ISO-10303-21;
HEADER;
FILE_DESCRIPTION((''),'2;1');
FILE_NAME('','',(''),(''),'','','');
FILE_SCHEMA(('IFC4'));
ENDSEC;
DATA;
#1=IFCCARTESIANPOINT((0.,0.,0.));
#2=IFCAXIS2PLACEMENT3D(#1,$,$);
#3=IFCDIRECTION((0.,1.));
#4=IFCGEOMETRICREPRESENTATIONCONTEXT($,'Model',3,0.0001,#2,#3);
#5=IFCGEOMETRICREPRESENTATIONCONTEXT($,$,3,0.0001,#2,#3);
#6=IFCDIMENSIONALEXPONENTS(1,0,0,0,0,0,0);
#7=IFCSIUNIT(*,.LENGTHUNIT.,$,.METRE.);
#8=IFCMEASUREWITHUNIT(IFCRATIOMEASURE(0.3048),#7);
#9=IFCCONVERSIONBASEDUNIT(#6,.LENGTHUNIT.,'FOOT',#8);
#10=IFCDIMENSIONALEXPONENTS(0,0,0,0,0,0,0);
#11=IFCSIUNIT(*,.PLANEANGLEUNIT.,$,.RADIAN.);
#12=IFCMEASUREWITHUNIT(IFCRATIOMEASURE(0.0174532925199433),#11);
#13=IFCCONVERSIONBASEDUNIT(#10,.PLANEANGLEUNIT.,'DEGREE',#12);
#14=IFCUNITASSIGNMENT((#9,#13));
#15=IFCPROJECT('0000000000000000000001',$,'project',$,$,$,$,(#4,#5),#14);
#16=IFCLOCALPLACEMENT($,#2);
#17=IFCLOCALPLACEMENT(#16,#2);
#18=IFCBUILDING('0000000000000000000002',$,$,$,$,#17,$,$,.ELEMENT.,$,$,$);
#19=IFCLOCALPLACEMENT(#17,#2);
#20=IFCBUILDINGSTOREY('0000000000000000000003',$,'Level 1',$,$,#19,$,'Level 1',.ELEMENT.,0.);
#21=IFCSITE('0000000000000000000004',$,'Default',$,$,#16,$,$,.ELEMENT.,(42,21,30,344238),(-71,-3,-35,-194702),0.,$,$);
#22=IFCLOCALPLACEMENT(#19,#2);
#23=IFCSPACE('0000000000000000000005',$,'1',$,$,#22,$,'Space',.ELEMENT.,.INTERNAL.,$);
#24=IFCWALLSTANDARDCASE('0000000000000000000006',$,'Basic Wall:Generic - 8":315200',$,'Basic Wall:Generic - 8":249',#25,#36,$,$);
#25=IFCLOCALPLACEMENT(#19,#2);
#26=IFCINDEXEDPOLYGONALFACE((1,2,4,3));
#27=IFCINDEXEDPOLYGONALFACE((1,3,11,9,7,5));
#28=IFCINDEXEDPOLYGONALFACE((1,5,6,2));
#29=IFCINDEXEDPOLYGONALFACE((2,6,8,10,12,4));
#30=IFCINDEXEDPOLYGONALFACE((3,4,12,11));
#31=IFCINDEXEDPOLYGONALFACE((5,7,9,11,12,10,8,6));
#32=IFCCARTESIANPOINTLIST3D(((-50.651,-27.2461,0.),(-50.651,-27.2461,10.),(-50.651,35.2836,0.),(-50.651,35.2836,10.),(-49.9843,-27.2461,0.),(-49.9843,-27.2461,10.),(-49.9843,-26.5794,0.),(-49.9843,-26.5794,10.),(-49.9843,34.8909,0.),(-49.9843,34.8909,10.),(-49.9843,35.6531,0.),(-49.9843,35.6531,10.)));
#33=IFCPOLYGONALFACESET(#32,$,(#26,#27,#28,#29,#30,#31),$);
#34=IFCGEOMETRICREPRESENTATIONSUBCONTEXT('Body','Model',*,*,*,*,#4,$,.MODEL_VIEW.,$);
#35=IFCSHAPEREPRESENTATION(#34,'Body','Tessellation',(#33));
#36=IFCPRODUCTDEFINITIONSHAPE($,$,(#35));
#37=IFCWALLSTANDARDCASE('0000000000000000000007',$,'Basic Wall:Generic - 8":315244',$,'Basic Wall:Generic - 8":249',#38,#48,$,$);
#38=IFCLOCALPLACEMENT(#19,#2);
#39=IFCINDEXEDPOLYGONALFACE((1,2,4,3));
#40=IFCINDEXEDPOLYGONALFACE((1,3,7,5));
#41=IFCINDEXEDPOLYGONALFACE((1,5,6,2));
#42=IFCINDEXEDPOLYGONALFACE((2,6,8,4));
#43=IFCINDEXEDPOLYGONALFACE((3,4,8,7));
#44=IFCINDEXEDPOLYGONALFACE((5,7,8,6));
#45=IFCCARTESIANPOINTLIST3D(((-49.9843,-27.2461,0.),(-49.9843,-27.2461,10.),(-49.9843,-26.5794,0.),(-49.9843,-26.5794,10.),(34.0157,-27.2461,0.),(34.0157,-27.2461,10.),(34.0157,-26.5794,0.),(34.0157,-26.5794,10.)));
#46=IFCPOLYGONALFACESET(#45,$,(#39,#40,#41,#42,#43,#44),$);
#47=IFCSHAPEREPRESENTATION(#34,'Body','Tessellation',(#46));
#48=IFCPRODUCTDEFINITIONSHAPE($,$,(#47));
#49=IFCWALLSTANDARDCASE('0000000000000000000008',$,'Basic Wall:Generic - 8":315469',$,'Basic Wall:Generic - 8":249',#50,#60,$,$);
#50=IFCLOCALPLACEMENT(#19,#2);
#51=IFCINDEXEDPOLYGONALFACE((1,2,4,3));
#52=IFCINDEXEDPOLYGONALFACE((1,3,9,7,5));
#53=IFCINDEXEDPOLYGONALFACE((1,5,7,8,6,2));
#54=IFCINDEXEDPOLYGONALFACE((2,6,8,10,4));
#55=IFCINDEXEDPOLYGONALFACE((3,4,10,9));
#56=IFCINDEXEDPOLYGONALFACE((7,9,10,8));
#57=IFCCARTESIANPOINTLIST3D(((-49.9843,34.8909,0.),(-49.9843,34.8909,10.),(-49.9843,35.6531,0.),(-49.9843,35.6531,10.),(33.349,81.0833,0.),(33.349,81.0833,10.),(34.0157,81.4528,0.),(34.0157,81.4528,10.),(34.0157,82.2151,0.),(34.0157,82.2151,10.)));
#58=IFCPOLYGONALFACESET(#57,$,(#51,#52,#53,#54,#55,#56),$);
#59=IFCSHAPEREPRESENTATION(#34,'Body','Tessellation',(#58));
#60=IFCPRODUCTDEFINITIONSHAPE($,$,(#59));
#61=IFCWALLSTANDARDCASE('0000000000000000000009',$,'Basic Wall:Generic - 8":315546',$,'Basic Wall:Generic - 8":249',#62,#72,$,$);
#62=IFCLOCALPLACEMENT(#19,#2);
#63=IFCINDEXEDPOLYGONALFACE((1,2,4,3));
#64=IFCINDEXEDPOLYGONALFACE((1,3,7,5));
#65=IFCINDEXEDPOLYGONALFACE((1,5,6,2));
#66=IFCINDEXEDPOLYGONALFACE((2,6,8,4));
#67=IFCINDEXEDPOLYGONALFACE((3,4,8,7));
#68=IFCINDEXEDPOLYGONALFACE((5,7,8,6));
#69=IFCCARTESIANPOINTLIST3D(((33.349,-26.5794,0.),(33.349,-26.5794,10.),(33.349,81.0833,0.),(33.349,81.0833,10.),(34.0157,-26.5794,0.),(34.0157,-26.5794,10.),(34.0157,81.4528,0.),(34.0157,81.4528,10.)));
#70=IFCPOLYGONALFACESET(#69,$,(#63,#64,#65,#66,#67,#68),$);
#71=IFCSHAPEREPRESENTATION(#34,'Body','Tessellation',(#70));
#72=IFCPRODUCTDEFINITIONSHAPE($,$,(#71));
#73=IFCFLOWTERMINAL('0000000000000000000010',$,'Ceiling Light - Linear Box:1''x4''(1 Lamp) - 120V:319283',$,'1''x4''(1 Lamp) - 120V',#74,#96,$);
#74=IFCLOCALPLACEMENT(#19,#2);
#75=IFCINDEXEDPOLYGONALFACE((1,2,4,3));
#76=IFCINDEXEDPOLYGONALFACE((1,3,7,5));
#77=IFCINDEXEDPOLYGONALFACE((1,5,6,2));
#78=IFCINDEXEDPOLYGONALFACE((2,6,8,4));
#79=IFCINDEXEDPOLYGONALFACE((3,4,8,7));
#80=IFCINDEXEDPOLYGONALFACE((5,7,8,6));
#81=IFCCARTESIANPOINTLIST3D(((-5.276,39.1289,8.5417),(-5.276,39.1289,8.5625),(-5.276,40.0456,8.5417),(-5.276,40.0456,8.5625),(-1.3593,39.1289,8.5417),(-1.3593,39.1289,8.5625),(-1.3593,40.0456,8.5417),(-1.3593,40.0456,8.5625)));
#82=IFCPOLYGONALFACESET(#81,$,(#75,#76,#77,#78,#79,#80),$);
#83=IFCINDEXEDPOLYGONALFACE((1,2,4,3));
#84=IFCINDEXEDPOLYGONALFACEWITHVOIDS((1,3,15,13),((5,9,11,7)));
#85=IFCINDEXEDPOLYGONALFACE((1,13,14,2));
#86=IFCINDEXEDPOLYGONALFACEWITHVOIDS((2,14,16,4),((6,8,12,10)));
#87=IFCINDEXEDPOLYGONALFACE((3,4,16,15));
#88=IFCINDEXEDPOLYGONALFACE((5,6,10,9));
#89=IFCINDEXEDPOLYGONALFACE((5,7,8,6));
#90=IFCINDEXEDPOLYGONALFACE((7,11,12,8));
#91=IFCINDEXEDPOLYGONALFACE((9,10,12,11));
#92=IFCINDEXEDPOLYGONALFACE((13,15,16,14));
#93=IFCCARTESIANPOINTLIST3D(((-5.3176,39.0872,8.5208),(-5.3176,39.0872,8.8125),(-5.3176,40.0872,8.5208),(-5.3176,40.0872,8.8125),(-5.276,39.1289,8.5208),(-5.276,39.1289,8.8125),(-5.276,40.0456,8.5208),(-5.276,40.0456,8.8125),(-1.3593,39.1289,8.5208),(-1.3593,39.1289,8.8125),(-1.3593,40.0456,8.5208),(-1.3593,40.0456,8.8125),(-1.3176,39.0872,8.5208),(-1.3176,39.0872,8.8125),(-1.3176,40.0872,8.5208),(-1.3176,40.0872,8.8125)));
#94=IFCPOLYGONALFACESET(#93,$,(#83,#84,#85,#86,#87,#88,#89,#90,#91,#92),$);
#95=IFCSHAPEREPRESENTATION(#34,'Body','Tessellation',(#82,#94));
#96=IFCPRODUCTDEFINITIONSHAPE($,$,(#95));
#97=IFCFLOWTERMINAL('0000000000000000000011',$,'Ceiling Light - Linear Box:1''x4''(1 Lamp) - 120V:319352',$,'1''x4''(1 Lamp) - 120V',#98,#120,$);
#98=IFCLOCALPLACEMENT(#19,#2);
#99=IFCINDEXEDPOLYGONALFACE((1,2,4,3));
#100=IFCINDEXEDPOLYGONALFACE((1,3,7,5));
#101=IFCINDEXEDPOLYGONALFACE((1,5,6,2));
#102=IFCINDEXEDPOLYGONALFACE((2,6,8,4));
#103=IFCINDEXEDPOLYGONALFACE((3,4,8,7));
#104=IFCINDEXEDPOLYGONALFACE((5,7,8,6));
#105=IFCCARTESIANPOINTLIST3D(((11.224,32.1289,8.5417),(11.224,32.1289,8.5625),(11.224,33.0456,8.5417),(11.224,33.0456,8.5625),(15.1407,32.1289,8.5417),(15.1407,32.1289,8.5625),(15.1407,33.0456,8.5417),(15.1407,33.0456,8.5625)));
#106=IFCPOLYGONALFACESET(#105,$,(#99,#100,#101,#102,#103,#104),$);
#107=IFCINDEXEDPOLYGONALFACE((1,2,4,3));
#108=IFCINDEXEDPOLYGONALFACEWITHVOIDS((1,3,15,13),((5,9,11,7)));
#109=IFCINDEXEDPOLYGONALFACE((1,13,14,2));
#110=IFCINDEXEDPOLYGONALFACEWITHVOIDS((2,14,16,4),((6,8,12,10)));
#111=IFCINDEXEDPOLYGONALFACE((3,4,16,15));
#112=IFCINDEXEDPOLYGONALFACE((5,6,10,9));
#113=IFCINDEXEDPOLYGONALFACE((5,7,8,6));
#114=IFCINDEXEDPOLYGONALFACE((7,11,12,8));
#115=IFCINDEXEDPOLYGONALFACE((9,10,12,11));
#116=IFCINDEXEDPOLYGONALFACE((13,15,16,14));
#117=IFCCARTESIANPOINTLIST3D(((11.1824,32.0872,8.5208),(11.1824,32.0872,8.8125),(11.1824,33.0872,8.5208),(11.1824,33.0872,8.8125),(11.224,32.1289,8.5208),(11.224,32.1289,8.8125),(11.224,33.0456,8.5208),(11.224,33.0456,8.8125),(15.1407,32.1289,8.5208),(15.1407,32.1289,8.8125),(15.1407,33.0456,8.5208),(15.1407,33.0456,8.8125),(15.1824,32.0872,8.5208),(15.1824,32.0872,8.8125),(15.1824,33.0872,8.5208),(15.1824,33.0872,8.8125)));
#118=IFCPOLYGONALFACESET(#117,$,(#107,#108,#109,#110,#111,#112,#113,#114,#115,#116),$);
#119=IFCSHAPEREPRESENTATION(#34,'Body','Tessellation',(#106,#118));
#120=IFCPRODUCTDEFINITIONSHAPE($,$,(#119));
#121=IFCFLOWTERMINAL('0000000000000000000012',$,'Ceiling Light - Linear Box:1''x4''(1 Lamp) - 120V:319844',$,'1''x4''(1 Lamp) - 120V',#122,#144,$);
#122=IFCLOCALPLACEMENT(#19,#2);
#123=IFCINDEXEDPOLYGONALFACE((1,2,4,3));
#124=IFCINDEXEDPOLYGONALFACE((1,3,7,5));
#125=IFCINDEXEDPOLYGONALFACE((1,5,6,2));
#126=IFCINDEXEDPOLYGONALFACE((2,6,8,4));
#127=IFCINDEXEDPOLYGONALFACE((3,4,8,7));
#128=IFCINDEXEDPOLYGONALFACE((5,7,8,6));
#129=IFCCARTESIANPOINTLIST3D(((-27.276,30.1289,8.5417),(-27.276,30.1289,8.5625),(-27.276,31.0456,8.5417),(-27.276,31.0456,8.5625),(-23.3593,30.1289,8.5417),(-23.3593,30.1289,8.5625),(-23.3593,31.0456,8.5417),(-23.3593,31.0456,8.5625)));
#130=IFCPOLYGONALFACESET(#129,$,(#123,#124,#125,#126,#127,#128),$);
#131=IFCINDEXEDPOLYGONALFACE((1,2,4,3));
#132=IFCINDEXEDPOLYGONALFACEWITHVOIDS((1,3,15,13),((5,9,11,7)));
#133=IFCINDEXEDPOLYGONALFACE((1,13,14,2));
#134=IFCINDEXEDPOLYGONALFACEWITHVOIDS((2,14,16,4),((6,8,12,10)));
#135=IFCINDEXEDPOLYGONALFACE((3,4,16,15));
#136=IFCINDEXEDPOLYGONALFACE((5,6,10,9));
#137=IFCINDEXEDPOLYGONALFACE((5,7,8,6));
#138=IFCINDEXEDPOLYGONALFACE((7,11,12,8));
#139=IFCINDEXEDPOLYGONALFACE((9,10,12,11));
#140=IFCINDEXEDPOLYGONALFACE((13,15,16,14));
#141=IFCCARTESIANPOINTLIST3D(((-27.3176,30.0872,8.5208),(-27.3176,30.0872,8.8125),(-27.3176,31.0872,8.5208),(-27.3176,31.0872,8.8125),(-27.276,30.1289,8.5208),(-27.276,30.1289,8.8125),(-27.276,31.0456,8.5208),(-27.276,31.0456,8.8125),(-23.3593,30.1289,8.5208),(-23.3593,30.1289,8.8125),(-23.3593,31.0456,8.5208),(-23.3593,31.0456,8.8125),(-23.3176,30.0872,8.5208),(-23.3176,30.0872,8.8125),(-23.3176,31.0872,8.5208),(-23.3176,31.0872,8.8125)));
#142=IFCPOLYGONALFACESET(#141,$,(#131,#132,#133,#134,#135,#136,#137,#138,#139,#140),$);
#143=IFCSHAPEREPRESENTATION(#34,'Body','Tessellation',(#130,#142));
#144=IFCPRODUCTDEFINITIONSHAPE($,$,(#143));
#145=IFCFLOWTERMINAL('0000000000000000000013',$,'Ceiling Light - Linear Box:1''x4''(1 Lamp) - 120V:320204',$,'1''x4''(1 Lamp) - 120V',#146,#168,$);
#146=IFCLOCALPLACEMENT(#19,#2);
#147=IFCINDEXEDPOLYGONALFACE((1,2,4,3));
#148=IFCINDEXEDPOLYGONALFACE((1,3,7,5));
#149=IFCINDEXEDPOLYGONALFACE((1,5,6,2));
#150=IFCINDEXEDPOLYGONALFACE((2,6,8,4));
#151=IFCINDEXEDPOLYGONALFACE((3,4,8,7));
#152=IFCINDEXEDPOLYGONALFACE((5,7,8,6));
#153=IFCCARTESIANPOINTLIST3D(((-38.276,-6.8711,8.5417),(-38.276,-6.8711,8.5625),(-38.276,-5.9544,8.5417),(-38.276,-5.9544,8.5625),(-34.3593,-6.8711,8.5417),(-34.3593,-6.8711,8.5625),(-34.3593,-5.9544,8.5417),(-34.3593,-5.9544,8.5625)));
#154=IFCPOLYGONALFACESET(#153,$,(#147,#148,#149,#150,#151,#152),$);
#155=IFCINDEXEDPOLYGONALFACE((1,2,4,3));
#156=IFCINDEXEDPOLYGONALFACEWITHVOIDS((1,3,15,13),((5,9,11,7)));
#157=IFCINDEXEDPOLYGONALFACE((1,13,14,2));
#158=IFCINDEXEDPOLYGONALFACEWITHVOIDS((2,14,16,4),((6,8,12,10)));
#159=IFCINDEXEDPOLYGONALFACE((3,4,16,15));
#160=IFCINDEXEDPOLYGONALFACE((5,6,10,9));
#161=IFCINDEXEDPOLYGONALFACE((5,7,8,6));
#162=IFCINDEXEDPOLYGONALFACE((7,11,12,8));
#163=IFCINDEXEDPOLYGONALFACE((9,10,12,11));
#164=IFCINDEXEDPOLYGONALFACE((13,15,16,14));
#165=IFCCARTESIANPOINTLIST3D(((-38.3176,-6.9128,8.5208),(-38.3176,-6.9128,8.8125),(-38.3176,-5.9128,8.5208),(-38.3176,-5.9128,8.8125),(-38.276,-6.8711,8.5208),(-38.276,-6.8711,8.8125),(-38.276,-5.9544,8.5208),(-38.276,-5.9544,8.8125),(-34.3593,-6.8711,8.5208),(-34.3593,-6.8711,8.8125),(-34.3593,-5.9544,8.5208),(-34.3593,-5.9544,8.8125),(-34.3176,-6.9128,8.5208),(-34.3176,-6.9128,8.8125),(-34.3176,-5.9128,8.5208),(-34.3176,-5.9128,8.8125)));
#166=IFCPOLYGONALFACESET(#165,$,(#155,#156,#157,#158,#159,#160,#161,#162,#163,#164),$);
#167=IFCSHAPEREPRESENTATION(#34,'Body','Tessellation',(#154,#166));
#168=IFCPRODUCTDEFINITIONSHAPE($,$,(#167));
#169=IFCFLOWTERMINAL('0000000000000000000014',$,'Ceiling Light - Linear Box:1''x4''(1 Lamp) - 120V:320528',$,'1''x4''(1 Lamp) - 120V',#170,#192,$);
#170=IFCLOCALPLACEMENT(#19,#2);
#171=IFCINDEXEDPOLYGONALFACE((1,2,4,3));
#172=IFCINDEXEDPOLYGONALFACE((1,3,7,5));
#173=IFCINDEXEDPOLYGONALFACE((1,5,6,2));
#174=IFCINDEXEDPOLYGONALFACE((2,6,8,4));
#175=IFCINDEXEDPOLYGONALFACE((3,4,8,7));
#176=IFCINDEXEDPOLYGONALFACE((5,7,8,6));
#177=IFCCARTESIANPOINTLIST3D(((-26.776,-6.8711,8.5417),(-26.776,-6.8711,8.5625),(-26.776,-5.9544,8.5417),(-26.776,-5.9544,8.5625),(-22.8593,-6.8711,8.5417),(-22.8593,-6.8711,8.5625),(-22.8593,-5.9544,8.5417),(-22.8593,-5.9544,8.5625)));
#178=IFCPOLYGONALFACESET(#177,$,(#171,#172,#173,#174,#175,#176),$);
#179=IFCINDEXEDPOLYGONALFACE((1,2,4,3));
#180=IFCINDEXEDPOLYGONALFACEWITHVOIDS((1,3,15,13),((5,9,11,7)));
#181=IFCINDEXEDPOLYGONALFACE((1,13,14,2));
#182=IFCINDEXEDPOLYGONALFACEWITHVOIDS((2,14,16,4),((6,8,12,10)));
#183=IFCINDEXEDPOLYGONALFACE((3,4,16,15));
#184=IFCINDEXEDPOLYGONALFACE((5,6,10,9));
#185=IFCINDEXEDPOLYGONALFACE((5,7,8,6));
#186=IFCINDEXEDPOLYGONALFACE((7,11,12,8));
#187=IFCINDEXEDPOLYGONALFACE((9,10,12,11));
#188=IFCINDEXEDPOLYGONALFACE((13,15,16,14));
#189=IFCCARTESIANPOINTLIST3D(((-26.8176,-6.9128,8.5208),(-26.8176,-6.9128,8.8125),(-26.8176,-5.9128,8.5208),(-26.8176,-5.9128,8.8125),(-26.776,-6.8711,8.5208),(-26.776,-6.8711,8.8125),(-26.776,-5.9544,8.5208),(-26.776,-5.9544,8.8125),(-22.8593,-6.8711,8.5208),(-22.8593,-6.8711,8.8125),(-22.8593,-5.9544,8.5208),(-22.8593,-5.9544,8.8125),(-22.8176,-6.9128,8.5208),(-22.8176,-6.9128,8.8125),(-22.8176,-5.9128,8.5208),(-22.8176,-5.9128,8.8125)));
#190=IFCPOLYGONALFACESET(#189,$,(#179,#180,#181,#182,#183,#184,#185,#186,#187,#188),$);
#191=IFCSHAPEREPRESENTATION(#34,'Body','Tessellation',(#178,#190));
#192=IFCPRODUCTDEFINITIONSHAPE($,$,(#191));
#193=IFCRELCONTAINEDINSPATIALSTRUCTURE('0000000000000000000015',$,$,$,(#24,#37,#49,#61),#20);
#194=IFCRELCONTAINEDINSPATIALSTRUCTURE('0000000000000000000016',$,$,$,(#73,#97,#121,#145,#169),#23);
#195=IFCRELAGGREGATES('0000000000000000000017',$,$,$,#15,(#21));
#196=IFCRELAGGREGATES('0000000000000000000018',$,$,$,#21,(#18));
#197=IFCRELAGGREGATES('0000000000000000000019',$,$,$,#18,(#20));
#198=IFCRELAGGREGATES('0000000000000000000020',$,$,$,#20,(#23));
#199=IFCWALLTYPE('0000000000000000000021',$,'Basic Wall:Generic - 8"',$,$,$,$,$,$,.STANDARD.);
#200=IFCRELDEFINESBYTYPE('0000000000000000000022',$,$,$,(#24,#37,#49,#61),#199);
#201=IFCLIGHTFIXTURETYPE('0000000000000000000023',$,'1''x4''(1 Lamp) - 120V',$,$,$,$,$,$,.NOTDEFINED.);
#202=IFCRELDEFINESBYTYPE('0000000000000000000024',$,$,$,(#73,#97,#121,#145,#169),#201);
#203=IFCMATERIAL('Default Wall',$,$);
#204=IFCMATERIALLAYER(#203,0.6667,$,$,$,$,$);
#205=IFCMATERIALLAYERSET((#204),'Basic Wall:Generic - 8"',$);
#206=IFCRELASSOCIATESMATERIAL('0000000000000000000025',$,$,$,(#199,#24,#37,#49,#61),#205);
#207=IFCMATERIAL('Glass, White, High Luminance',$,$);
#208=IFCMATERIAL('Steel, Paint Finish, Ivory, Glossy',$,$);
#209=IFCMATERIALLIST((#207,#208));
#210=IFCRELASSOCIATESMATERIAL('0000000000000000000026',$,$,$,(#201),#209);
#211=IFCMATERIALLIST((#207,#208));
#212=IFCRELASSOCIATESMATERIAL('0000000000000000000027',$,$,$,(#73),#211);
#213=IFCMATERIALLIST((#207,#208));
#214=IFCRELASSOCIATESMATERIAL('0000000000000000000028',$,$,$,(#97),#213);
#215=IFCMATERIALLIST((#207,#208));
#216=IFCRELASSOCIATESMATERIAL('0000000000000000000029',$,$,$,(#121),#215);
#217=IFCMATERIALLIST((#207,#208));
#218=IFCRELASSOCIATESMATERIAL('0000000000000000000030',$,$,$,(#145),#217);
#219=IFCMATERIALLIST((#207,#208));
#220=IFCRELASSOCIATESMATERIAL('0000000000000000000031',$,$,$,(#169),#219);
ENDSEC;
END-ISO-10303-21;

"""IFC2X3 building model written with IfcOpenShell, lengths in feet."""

from ifc_helpers import new_model, entity, si_unit, converted_unit, direction, frame, frame_2d, origin, origin_2d_with_axis, place, context, subcontext, project, spatial, polyline, rectangle, outline, extrude, source, transform, mapped, material, material_list, layer, layer_set, layer_usage, type_object, type_shapes, element, save


model = new_model("IFC2X3")

# Units and contexts
model_context = context("Model", 3, precision=0.0001, world=origin(), true_north=direction((0.0, 1.0)))
context_of_model = context(None, 3, precision=0.0001, world=origin(), true_north=direction((0.0, 1.0)))
body_context = subcontext(model_context, "Body", "Model", "MODEL_VIEW")
ifc_project = project(units=[converted_unit("LENGTHUNIT", "FOOT", entity("IfcRatioMeasure", 0.3048), si_unit("LENGTHUNIT", "METRE"), dimensions=[1, 0, 0, 0, 0, 0, 0]), converted_unit("PLANEANGLEUNIT", "DEGREE", entity("IfcRatioMeasure", 0.0174532925199433), si_unit("PLANEANGLEUNIT", "RADIAN"), dimensions=[0, 0, 0, 0, 0, 0, 0])], contexts=[model_context, context_of_model])

# Site, building, storey
site_placement = place(None, origin())
site = spatial("IfcSite", under=ifc_project, at=site_placement, Name="Default", CompositionType="ELEMENT", RefLatitude=(42, 21, 30, 344238), RefLongitude=(-71, -3, -35, -194702), RefElevation=0.0)
building_placement = place(site_placement, origin())
building = spatial("IfcBuilding", under=site, at=building_placement, CompositionType="ELEMENT")
storey_placement = place(building_placement, origin())
storey = spatial("IfcBuildingStorey", under=building, at=storey_placement, Name="Level 1", LongName="Level 1", CompositionType="ELEMENT", Elevation=0.0)

# Walls
ifc_material_1 = material(Name="Default Wall")
ifc_layer_1 = layer(ifc_material_1, 0.6667)
ifc_layer_set_1 = layer_set([ifc_layer_1], Name="Basic Wall:Generic - 8\"")
ifc_layer_usage_1 = layer_usage(ifc_layer_set_1, "AXIS2", "NEGATIVE", 0.3333)
wall_type = type_object("IfcWallType", Name="Basic Wall:Generic - 8\"", PredefinedType="STANDARD", material=ifc_layer_set_1)
wall_1_placement = place(storey_placement, frame((-50.3176, 35.6531, 0.0), z_axis=(0.0, 0.0, 1.0), x_axis=(0.0, -1.0, 0.0)))
element("IfcWallStandardCase", 1, at=wall_1_placement, inside=storey, type_object=wall_type, material=ifc_layer_usage_1, Name="Basic Wall:Generic - 8\":315200", ObjectType="Basic Wall:Generic - 8\":249", context=body_context, shape_type="SweptSolid", body=[
    extrude(outline(polyline([(62.8992, -0.3333), (62.8992, 0.3333), (62.2326, 0.3333), (0.7622, 0.3333), (0.0, 0.3333), (0.3695, -0.3333), (62.8992, -0.3333)])), origin(), (0.0, 0.0, 1.0), 10.0),
])
ifc_layer_usage_2 = layer_usage(ifc_layer_set_1, "AXIS2", "NEGATIVE", 0.3333)
wall_2_placement = place(storey_placement, frame((-49.9843, -26.9128, 0.0)))
element("IfcWallStandardCase", 2, at=wall_2_placement, inside=storey, type_object=wall_type, material=ifc_layer_usage_2, Name="Basic Wall:Generic - 8\":315244", ObjectType="Basic Wall:Generic - 8\":249", context=body_context, shape_type="SweptSolid", body=[
    extrude(rectangle(XDim=84.0, YDim=0.6667, at=frame_2d((42.0, 0.0), x_axis=(-1.0, 0.0))), origin(), (0.0, 0.0, 1.0), 10.0),
])
ifc_layer_usage_3 = layer_usage(ifc_layer_set_1, "AXIS2", "NEGATIVE", 0.3333)
wall_3_placement = place(storey_placement, frame((-50.1459, 35.1824, 0.0), z_axis=(0.0, 0.0, 1.0), x_axis=(0.87462, 0.48481, 0.0)))
element("IfcWallStandardCase", 3, at=wall_3_placement, inside=storey, type_object=wall_type, material=ifc_layer_usage_3, Name="Basic Wall:Generic - 8\":315469", ObjectType="Basic Wall:Generic - 8\":249", context=body_context, shape_type="SweptSolid", body=[
    extrude(outline(polyline([(96.0417, -0.3333), (96.4113, 0.3333), (0.3695, 0.3333), (0.0, -0.3333), (95.2795, -0.3333), (96.0417, -0.3333)])), origin(), (0.0, 0.0, 1.0), 10.0),
])
ifc_layer_usage_4 = layer_usage(ifc_layer_set_1, "AXIS2", "NEGATIVE", 0.3333)
wall_4_placement = place(storey_placement, frame((33.6824, 81.4528, 0.0), z_axis=(0.0, 0.0, 1.0), x_axis=(0.0, -1.0, 0.0)))
element("IfcWallStandardCase", 4, at=wall_4_placement, inside=storey, type_object=wall_type, material=ifc_layer_usage_4, Name="Basic Wall:Generic - 8\":315546", ObjectType="Basic Wall:Generic - 8\":249", context=body_context, shape_type="SweptSolid", body=[
    extrude(outline(polyline([(108.0323, -0.3333), (108.0323, 0.3333), (0.0, 0.3333), (0.3695, -0.3333), (108.0323, -0.3333)])), origin(), (0.0, 0.0, 1.0), 10.0),
])

# Shared definitions
space_placement = place(storey_placement, origin())
space = spatial("IfcSpace", under=storey, at=space_placement, Name="1", LongName="Space", CompositionType="ELEMENT", InteriorOrExteriorSpace="INTERNAL")

# Flow terminals
ifc_material_2 = material(Name="Glass, White, High Luminance")
ifc_material_3 = material(Name="Steel, Paint Finish, Ivory, Glossy")
ifc_material_list_1 = material_list([ifc_material_2, ifc_material_3])
ifc_material_list_2 = material_list([ifc_material_2, ifc_material_3])
light_fixture_type = type_object("IfcLightFixtureType", Name="1'x4'(1 Lamp) - 120V", PredefinedType="NOTDEFINED", material=ifc_material_list_2)
shared_shape = source(origin(), body_context, "Body", "SweptSolid", [
    extrude(rectangle(XDim=3.9167, YDim=0.9167, at=origin_2d_with_axis()), frame((0.0, 0.0, 7.7292), z_axis=(0.0, 0.0, 1.0), x_axis=(-1.0, 0.0, 0.0)), (0.0, 0.0, 1.0), 0.0208),
    extrude(outline(polyline([(-2.0, -0.5), (2.0, -0.5), (2.0, 0.5), (-2.0, 0.5), (-2.0, -0.5)]), holes=[polyline([(-1.9583, -0.4583), (-1.9583, 0.4583), (1.9583, 0.4583), (1.9583, -0.4583), (-1.9583, -0.4583)])]), frame((0.0, 0.0, 7.7083), z_axis=(0.0, 0.0, 1.0), x_axis=(-1.0, 0.0, 0.0)), (0.0, 0.0, 1.0), 0.2917),
])
type_shapes(light_fixture_type, [shared_shape])
flow_terminal_1_placement = place(space_placement, frame((-3.3176, 39.5872, 0.8125)))
element("IfcFlowTerminal", 5, at=flow_terminal_1_placement, inside=space, type_object=light_fixture_type, material=ifc_material_list_1, Name="Ceiling Light - Linear Box:1'x4'(1 Lamp) - 120V:319283", ObjectType="1'x4'(1 Lamp) - 120V", context=body_context, shape_type="MappedRepresentation", body=[
    mapped(shared_shape, transform((0.0, 0.0, 0.0), scale=1.0)),
])
ifc_material_list_3 = material_list([ifc_material_2, ifc_material_3])
flow_terminal_2_placement = place(space_placement, frame((13.1824, 32.5872, 0.8125)))
element("IfcFlowTerminal", 6, at=flow_terminal_2_placement, inside=space, type_object=light_fixture_type, material=ifc_material_list_3, Name="Ceiling Light - Linear Box:1'x4'(1 Lamp) - 120V:319352", ObjectType="1'x4'(1 Lamp) - 120V", context=body_context, shape_type="MappedRepresentation", body=[
    mapped(shared_shape, transform((0.0, 0.0, 0.0), scale=1.0)),
])
ifc_material_list_4 = material_list([ifc_material_2, ifc_material_3])
flow_terminal_3_placement = place(space_placement, frame((-25.3176, 30.5872, 0.8125)))
element("IfcFlowTerminal", 7, at=flow_terminal_3_placement, inside=space, type_object=light_fixture_type, material=ifc_material_list_4, Name="Ceiling Light - Linear Box:1'x4'(1 Lamp) - 120V:319844", ObjectType="1'x4'(1 Lamp) - 120V", context=body_context, shape_type="MappedRepresentation", body=[
    mapped(shared_shape, transform((0.0, 0.0, 0.0), scale=1.0)),
])
ifc_material_list_5 = material_list([ifc_material_2, ifc_material_3])
flow_terminal_4_placement = place(space_placement, frame((-36.3176, -6.4128, 0.8125)))
element("IfcFlowTerminal", 8, at=flow_terminal_4_placement, inside=space, type_object=light_fixture_type, material=ifc_material_list_5, Name="Ceiling Light - Linear Box:1'x4'(1 Lamp) - 120V:320204", ObjectType="1'x4'(1 Lamp) - 120V", context=body_context, shape_type="MappedRepresentation", body=[
    mapped(shared_shape, transform((0.0, 0.0, 0.0), scale=1.0)),
])
ifc_material_list_6 = material_list([ifc_material_2, ifc_material_3])
flow_terminal_5_placement = place(space_placement, frame((-24.8176, -6.4128, 0.8125)))
element("IfcFlowTerminal", 9, at=flow_terminal_5_placement, inside=space, type_object=light_fixture_type, material=ifc_material_list_6, Name="Ceiling Light - Linear Box:1'x4'(1 Lamp) - 120V:320528", ObjectType="1'x4'(1 Lamp) - 120V", context=body_context, shape_type="MappedRepresentation", body=[
    mapped(shared_shape, transform((0.0, 0.0, 0.0), scale=1.0)),
])

save(model, "model.ifc")
